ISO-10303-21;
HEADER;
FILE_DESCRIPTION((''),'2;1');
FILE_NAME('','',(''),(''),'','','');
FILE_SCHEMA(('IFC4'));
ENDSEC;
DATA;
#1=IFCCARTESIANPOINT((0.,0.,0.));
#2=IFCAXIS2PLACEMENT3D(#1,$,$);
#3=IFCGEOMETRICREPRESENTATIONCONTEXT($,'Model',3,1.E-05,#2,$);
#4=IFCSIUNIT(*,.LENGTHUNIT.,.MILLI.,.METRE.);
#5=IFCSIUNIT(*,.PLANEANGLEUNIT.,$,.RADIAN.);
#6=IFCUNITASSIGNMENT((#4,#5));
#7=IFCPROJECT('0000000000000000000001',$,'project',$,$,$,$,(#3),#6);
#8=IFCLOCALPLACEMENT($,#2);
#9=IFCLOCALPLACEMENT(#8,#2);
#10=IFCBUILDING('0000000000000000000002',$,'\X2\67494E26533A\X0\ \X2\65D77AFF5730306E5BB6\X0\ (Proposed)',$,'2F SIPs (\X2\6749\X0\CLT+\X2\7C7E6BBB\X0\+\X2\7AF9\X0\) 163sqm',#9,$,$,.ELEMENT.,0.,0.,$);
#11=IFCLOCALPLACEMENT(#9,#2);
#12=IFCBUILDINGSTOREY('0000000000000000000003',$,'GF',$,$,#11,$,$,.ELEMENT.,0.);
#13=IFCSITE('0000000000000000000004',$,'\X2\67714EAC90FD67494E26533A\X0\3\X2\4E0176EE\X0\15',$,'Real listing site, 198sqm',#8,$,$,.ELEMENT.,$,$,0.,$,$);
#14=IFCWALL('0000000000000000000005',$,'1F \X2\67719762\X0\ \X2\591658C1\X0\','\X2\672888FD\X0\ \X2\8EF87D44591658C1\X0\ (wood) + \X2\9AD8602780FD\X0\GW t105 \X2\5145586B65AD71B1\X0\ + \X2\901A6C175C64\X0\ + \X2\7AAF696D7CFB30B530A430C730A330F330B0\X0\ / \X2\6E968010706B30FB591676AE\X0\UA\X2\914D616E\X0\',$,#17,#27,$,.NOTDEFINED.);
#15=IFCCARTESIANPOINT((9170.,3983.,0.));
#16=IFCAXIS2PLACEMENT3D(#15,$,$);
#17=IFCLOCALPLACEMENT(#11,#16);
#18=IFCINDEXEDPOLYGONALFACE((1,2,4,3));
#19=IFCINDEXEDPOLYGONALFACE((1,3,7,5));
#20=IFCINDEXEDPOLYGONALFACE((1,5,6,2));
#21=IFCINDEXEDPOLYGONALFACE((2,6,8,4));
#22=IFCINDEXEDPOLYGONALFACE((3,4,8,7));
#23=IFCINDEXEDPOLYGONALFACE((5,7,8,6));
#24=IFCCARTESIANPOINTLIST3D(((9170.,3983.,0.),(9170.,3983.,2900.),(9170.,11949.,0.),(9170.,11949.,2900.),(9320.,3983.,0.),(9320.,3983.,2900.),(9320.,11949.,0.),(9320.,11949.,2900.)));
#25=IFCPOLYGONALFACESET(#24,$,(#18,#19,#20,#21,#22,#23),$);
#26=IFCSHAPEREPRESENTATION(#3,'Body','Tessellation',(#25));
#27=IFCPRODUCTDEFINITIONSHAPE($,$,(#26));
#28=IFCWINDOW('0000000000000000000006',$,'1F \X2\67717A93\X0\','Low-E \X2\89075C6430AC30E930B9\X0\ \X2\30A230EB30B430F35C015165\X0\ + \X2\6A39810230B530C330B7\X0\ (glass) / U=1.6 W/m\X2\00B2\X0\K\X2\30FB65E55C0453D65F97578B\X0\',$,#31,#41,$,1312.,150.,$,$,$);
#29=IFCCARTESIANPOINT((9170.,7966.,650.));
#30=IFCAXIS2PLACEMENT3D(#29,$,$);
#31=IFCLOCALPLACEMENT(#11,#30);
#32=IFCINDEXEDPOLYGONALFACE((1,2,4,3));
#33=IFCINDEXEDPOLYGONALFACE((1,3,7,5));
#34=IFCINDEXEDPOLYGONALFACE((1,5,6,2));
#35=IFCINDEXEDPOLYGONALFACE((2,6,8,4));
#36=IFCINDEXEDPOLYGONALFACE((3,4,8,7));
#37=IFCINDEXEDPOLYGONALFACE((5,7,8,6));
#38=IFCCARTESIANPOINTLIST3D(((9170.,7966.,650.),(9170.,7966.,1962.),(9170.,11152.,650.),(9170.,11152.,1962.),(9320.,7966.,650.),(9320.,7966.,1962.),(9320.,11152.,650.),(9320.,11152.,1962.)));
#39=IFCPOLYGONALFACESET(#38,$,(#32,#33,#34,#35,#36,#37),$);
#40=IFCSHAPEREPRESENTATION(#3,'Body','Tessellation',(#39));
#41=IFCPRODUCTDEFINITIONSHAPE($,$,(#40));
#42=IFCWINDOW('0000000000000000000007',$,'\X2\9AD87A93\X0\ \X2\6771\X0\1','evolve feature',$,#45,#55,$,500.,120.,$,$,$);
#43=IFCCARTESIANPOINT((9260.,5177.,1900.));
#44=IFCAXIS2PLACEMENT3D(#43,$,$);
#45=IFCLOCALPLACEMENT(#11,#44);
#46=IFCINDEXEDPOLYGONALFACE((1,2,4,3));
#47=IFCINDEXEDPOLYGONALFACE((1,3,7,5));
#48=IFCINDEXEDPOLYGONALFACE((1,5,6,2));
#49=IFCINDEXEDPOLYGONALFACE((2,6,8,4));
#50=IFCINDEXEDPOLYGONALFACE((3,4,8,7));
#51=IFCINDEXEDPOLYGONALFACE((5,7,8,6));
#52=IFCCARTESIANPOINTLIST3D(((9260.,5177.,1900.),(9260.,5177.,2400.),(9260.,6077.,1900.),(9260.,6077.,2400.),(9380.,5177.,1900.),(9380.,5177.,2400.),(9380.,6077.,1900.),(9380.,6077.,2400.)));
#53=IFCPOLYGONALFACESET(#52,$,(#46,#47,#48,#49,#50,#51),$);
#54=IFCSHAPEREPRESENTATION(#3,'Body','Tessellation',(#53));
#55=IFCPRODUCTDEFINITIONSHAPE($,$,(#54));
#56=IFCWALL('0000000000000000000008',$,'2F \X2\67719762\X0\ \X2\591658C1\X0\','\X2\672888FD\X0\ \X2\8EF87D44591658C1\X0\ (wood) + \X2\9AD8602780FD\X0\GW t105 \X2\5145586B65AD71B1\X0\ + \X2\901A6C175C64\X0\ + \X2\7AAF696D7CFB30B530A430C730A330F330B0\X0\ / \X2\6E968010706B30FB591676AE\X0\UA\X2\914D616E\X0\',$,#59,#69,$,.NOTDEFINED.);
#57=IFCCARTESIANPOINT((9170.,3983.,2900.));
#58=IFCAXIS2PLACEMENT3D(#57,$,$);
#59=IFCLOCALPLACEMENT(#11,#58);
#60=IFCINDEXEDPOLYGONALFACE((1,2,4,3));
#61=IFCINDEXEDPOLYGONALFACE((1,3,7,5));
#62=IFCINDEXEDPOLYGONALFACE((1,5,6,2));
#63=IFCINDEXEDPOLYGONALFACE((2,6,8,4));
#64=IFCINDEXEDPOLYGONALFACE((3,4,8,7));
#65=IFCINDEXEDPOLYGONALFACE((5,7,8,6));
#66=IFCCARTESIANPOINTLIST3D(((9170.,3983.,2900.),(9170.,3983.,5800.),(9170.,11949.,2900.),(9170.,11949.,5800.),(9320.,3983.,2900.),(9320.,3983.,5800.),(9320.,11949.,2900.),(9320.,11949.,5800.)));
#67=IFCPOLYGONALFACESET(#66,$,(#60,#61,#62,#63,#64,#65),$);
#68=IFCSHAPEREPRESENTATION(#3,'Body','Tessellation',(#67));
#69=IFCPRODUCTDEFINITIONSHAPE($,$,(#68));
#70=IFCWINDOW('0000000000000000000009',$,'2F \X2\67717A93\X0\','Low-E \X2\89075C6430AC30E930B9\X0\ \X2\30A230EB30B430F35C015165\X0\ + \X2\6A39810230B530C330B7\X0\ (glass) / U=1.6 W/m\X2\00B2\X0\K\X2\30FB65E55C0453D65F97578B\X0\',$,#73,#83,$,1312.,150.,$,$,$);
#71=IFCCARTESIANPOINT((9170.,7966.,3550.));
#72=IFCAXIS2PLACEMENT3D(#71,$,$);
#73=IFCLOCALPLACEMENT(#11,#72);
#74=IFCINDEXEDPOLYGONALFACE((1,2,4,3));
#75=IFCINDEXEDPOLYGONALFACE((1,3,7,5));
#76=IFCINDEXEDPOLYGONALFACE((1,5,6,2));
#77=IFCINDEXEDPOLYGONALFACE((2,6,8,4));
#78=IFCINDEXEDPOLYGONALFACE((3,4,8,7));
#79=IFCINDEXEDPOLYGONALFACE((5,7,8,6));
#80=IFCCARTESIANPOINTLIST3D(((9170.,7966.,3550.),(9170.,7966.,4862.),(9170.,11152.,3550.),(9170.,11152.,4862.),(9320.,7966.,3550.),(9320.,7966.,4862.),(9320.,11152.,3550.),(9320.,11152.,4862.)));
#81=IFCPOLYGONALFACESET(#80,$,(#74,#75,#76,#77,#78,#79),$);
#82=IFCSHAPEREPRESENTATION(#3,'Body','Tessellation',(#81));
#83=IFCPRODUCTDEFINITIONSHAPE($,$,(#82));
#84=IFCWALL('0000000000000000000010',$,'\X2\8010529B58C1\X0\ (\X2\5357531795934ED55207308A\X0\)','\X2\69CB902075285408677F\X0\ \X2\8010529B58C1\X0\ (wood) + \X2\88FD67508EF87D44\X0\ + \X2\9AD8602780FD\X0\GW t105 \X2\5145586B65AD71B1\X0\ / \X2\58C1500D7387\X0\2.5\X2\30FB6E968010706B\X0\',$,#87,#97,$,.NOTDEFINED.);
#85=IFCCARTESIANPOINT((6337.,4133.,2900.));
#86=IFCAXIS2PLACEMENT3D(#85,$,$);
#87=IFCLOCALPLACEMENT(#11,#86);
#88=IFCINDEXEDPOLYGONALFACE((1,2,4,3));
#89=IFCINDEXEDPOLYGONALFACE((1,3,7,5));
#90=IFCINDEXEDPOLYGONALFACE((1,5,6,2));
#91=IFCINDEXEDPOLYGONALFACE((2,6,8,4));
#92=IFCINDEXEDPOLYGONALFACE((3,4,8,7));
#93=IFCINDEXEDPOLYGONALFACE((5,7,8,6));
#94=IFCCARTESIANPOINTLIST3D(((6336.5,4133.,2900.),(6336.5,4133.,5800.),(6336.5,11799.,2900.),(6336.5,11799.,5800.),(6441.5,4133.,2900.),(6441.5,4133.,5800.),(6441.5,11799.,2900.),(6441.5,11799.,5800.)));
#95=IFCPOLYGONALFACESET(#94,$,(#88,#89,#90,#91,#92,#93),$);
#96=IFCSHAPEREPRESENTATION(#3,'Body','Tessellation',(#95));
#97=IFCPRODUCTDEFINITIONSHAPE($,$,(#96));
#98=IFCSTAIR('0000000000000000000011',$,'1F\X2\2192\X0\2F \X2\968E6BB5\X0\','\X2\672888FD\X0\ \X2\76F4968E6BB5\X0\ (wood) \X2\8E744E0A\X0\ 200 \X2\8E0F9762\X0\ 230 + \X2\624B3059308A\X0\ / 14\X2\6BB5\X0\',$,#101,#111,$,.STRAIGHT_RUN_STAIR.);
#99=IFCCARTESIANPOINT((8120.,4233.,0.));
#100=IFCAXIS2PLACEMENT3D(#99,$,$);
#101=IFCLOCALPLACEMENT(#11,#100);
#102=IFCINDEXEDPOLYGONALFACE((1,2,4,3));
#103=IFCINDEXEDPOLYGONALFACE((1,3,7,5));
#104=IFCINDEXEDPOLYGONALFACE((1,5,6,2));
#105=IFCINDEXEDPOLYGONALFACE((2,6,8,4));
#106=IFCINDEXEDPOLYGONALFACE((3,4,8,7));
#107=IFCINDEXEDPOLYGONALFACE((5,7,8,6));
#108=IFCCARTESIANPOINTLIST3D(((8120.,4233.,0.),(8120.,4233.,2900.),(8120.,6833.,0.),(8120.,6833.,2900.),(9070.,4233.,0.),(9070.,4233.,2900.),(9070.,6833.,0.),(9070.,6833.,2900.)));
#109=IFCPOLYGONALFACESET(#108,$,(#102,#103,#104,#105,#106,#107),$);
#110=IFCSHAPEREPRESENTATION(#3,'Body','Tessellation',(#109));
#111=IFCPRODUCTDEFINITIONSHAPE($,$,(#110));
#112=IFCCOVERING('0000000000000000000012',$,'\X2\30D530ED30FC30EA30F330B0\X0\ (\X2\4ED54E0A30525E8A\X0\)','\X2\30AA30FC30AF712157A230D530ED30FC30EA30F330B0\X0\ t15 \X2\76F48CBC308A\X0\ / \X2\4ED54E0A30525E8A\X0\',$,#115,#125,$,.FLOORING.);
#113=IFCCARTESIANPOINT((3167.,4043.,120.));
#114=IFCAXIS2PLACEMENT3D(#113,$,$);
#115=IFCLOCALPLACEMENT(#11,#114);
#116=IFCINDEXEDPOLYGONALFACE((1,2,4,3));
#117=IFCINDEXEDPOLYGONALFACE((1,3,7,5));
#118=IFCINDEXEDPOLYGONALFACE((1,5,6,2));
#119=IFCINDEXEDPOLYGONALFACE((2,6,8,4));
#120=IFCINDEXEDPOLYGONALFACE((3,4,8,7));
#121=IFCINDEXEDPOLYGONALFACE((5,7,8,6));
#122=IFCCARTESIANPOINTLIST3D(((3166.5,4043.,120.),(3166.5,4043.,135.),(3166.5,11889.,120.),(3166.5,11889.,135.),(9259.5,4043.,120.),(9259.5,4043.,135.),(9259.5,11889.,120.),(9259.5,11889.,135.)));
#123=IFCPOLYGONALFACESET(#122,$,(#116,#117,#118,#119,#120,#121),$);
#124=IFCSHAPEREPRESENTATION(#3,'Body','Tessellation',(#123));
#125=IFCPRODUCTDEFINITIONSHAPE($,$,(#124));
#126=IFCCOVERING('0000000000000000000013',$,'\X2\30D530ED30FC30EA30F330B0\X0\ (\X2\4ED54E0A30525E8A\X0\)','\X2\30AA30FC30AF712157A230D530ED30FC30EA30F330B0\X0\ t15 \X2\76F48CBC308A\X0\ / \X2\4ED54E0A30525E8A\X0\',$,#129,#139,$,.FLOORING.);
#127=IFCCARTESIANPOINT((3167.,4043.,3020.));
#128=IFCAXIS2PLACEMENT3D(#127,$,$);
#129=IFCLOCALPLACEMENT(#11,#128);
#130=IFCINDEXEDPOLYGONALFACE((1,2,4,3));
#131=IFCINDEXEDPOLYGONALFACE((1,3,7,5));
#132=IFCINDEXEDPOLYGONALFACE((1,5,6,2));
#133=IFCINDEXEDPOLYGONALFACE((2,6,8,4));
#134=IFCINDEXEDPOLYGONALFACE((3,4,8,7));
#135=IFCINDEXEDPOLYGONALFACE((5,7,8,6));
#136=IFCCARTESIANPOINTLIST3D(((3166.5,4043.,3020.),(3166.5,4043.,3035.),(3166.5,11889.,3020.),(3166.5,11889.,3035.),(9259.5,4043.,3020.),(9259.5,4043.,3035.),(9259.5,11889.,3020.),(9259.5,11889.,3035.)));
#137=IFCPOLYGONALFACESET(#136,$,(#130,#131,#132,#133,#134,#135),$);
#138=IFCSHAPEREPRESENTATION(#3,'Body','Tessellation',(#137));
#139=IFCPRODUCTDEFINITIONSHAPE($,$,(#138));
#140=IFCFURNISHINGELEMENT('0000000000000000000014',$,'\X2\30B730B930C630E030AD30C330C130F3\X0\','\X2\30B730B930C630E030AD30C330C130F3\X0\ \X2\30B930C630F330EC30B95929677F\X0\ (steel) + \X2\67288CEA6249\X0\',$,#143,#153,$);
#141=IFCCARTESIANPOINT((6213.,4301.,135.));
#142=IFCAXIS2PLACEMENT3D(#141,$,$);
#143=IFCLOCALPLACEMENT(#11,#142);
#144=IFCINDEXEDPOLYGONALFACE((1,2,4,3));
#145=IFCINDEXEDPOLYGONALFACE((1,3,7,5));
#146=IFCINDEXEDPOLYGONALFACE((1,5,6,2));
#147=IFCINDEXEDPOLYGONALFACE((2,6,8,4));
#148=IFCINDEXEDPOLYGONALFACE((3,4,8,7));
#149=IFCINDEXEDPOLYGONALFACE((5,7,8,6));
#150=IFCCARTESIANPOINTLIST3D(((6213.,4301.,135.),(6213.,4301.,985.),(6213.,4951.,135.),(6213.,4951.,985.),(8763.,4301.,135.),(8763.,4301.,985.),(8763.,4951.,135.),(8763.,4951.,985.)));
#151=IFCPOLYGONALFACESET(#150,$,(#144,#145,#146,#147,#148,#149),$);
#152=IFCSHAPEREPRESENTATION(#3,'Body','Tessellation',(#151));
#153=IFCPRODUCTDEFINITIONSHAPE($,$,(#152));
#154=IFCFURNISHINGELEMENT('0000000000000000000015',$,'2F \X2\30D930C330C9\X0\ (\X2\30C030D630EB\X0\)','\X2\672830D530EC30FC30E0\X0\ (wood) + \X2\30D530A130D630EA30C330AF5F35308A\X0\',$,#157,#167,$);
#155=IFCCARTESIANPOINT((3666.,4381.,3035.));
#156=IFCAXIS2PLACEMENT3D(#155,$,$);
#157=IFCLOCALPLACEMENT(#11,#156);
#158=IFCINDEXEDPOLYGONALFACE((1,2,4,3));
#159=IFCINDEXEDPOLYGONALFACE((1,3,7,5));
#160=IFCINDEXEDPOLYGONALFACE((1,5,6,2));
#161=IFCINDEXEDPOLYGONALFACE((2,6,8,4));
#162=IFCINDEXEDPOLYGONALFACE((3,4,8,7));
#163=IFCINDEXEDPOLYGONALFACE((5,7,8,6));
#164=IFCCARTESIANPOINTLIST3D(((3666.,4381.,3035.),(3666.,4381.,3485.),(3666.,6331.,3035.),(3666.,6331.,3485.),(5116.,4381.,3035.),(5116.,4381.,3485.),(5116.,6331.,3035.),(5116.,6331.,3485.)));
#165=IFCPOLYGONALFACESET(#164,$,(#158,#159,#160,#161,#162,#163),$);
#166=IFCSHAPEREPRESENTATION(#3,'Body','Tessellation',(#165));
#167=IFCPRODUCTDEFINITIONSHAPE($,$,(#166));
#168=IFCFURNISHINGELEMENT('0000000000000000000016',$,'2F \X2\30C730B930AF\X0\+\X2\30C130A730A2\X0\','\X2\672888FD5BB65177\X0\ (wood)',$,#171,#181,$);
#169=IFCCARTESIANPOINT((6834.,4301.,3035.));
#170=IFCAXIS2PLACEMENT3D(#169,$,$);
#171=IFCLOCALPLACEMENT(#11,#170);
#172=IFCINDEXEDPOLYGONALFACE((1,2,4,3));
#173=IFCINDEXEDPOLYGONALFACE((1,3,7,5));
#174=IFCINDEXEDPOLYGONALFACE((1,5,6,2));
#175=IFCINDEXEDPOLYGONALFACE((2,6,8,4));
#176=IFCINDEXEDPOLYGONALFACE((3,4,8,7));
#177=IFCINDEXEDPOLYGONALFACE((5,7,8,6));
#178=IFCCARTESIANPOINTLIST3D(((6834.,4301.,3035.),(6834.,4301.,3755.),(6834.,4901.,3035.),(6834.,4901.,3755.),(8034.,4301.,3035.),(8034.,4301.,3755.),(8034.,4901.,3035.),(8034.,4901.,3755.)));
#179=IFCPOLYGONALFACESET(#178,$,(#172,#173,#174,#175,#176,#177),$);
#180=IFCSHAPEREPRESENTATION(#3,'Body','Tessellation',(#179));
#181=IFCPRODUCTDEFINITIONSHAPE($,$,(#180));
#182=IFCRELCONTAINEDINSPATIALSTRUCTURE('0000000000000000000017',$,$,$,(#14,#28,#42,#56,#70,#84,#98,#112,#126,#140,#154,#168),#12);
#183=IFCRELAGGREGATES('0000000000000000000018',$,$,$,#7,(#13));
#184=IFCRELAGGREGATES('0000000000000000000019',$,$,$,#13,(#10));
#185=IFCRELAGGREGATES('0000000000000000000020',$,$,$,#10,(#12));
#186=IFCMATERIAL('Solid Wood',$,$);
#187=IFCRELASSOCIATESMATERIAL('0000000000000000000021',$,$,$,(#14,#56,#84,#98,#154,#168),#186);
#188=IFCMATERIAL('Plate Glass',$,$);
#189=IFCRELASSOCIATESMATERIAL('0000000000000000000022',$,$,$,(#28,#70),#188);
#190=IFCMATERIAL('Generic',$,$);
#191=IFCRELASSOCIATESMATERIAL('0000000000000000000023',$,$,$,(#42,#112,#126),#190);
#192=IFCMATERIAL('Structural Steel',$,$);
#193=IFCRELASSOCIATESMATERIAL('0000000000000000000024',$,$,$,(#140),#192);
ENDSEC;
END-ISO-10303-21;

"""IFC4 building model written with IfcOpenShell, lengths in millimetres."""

from ifc_helpers import new_model, si_unit, frame, frame_2d, origin, place, context, project, spatial, rectangle, extrude, material, element, fill, save


model = new_model("IFC4")

# Units and contexts
model_context = context("Model", 3, precision=1e-05, world=origin())
ifc_project = project(units=[si_unit("LENGTHUNIT", "METRE", prefix="MILLI"), si_unit("PLANEANGLEUNIT", "RADIAN")], contexts=[model_context])

# Site, building, storey
site_placement = place(None, origin())
site = spatial("IfcSite", under=ifc_project, at=site_placement, Name="東京都杉並区3丁目15", ObjectType="Real listing site, 198sqm", CompositionType="ELEMENT", RefElevation=0.0)
building_placement = place(site_placement, origin())
building = spatial("IfcBuilding", under=site, at=building_placement, Name="杉並区 旗竿地の家 (Proposed)", ObjectType="2F SIPs (杉CLT+籾殻+竹) 163sqm", CompositionType="ELEMENT", ElevationOfRefHeight=0.0, ElevationOfTerrain=0.0)
storey_placement = place(building_placement, origin())
storey = spatial("IfcBuildingStorey", under=building, at=storey_placement, Name="GF", CompositionType="ELEMENT", Elevation=0.0)

# Shared definitions
ifc_material_1 = material(Name="Solid Wood")

# Wall, openings, windows
wall_1_placement = place(storey_placement, frame((9170.0, 3983.0, 0.0)))
wall_1 = element("IfcWall", 1, at=wall_1_placement, inside=storey, material=ifc_material_1, Name="1F 東面 外壁", Description="木製 軸組外壁 (wood) + 高性能GW t105 充填断熱 + 通気層 + 窯業系サイディング / 準耐火・外皮UA配慮", PredefinedType="NOTDEFINED", context=model_context, shape_type="SweptSolid", body=[
    extrude(rectangle(XDim=150.0, YDim=7966.0, at=frame_2d((75.0, 3983.0))), frame((9170.0, 3983.0, 0.0)), (0.0, 0.0, 1.0), 2900.0),
])
opening_1_placement = place(storey_placement, frame((9170.0, 7966.0, 650.0)))
opening_1 = element("IfcOpeningElement", 2, at=opening_1_placement, cuts=wall_1, PredefinedType="NOTDEFINED", context=model_context, shape_type="SweptSolid", body=[
    extrude(rectangle(XDim=150.0, YDim=3186.0, at=frame_2d((75.0, 1593.0))), frame((9170.0, 7966.0, 650.0)), (0.0, 0.0, 1.0), 1312.0),
])
opening_2_placement = place(storey_placement, frame((9260.0, 5177.0, 1900.0)))
opening_2 = element("IfcOpeningElement", 3, at=opening_2_placement, cuts=wall_1, PredefinedType="NOTDEFINED", context=model_context, shape_type="SweptSolid", body=[
    extrude(rectangle(XDim=120.0, YDim=900.0, at=frame_2d((60.0, 450.0))), frame((9260.0, 5177.0, 1900.0)), (0.0, 0.0, 1.0), 500.0),
])
ifc_material_2 = material(Name="Plate Glass")
window_1_placement = place(storey_placement, frame((9170.0, 7966.0, 650.0)))
window_1 = element("IfcWindow", 4, at=window_1_placement, inside=storey, material=ifc_material_2, Name="1F 東窓", Description="Low-E 複層ガラス アルゴン封入 + 樹脂サッシ (glass) / U=1.6 W/m²K・日射取得型", OverallHeight=1312.0, OverallWidth=150.0, context=model_context, shape_type="SweptSolid", body=[
    extrude(rectangle(XDim=150.0, YDim=3186.0, at=frame_2d((75.0, 1593.0))), frame((9170.0, 7966.0, 650.0)), (0.0, 0.0, 1.0), 1312.0),
])
fill(opening_1, window_1)
ifc_material_3 = material(Name="Generic")
window_2_placement = place(storey_placement, frame((9260.0, 5177.0, 1900.0)))
window_2 = element("IfcWindow", 5, at=window_2_placement, inside=storey, material=ifc_material_3, Name="高窓 東1", Description="evolve feature", OverallHeight=500.0, OverallWidth=120.0, context=model_context, shape_type="SweptSolid", body=[
    extrude(rectangle(XDim=120.0, YDim=900.0, at=frame_2d((60.0, 450.0))), frame((9260.0, 5177.0, 1900.0)), (0.0, 0.0, 1.0), 500.0),
])
fill(opening_2, window_2)

# Wall, opening, window
wall_2_placement = place(storey_placement, frame((9170.0, 3983.0, 2900.0)))
wall_2 = element("IfcWall", 6, at=wall_2_placement, inside=storey, material=ifc_material_1, Name="2F 東面 外壁", Description="木製 軸組外壁 (wood) + 高性能GW t105 充填断熱 + 通気層 + 窯業系サイディング / 準耐火・外皮UA配慮", PredefinedType="NOTDEFINED", context=model_context, shape_type="SweptSolid", body=[
    extrude(rectangle(XDim=150.0, YDim=7966.0, at=frame_2d((75.0, 3983.0))), frame((9170.0, 3983.0, 2900.0)), (0.0, 0.0, 1.0), 2900.0),
])
opening_3_placement = place(storey_placement, frame((9170.0, 7966.0, 3550.0)))
opening_3 = element("IfcOpeningElement", 7, at=opening_3_placement, cuts=wall_2, PredefinedType="NOTDEFINED", context=model_context, shape_type="SweptSolid", body=[
    extrude(rectangle(XDim=150.0, YDim=3186.0, at=frame_2d((75.0, 1593.0))), frame((9170.0, 7966.0, 3550.0)), (0.0, 0.0, 1.0), 1312.0),
])
window_3_placement = place(storey_placement, frame((9170.0, 7966.0, 3550.0)))
window_3 = element("IfcWindow", 8, at=window_3_placement, inside=storey, material=ifc_material_2, Name="2F 東窓", Description="Low-E 複層ガラス アルゴン封入 + 樹脂サッシ (glass) / U=1.6 W/m²K・日射取得型", OverallHeight=1312.0, OverallWidth=150.0, context=model_context, shape_type="SweptSolid", body=[
    extrude(rectangle(XDim=150.0, YDim=3186.0, at=frame_2d((75.0, 1593.0))), frame((9170.0, 7966.0, 3550.0)), (0.0, 0.0, 1.0), 1312.0),
])
fill(opening_3, window_3)

# Wall
wall_3_placement = place(storey_placement, frame((6337.0, 4133.0, 2900.0)))
element("IfcWall", 9, at=wall_3_placement, inside=storey, material=ifc_material_1, Name="耐力壁 (南北間仕切り)", Description="構造用合板 耐力壁 (wood) + 製材軸組 + 高性能GW t105 充填断熱 / 壁倍率2.5・準耐火", PredefinedType="NOTDEFINED", context=model_context, shape_type="SweptSolid", body=[
    extrude(rectangle(XDim=105.0, YDim=7666.0, at=frame_2d((52.0, 3833.0))), frame((6337.0, 4133.0, 2900.0)), (0.0, 0.0, 1.0), 2900.0),
])

# Stair
stair_placement = place(storey_placement, frame((8120.0, 4233.0, 0.0)))
element("IfcStair", 10, at=stair_placement, inside=storey, material=ifc_material_1, Name="1F→2F 階段", Description="木製 直階段 (wood) 蹴上 200 踏面 230 + 手すり / 14段", PredefinedType="STRAIGHT_RUN_STAIR", context=model_context, shape_type="SweptSolid", body=[
    extrude(rectangle(XDim=950.0, YDim=2600.0, at=frame_2d((475.0, 1300.0))), frame((8120.0, 4233.0, 0.0)), (0.0, 0.0, 1.0), 2900.0),
])

# Coverings
covering_1_placement = place(storey_placement, frame((3167.0, 4043.0, 120.0)))
element("IfcCovering", 11, at=covering_1_placement, inside=storey, material=ifc_material_3, Name="フローリング (仕上げ床)", Description="オーク無垢フローリング t15 直貼り / 仕上げ床", PredefinedType="FLOORING", context=model_context, shape_type="SweptSolid", body=[
    extrude(rectangle(XDim=6093.0, YDim=7846.0, at=frame_2d((3046.0, 3923.0))), frame((3167.0, 4043.0, 120.0)), (0.0, 0.0, 1.0), 15.0),
])
covering_2_placement = place(storey_placement, frame((3167.0, 4043.0, 3020.0)))
element("IfcCovering", 12, at=covering_2_placement, inside=storey, material=ifc_material_3, Name="フローリング (仕上げ床)", Description="オーク無垢フローリング t15 直貼り / 仕上げ床", PredefinedType="FLOORING", context=model_context, shape_type="SweptSolid", body=[
    extrude(rectangle(XDim=6093.0, YDim=7846.0, at=frame_2d((3046.0, 3923.0))), frame((3167.0, 4043.0, 3020.0)), (0.0, 0.0, 1.0), 15.0),
])

# Furnishing elements
ifc_material_4 = material(Name="Structural Steel")
furnishing_1_placement = place(storey_placement, frame((6213.0, 4301.0, 135.0)))
element("IfcFurnishingElement", 13, at=furnishing_1_placement, inside=storey, material=ifc_material_4, Name="システムキッチン", Description="システムキッチン ステンレス天板 (steel) + 木質扉", context=model_context, shape_type="SweptSolid", body=[
    extrude(rectangle(XDim=2550.0, YDim=650.0, at=frame_2d((1275.0, 325.0))), frame((6213.0, 4301.0, 135.0)), (0.0, 0.0, 1.0), 850.0),
])
furnishing_2_placement = place(storey_placement, frame((3666.0, 4381.0, 3035.0)))
element("IfcFurnishingElement", 14, at=furnishing_2_placement, inside=storey, material=ifc_material_1, Name="2F ベッド (ダブル)", Description="木フレーム (wood) + ファブリック張り", context=model_context, shape_type="SweptSolid", body=[
    extrude(rectangle(XDim=1450.0, YDim=1950.0, at=frame_2d((725.0, 975.0))), frame((3666.0, 4381.0, 3035.0)), (0.0, 0.0, 1.0), 450.0),
])
furnishing_3_placement = place(storey_placement, frame((6834.0, 4301.0, 3035.0)))
element("IfcFurnishingElement", 15, at=furnishing_3_placement, inside=storey, material=ifc_material_1, Name="2F デスク+チェア", Description="木製家具 (wood)", context=model_context, shape_type="SweptSolid", body=[
    extrude(rectangle(XDim=1200.0, YDim=600.0, at=frame_2d((600.0, 300.0))), frame((6834.0, 4301.0, 3035.0)), (0.0, 0.0, 1.0), 720.0),
])

save(model, "model.ifc")
